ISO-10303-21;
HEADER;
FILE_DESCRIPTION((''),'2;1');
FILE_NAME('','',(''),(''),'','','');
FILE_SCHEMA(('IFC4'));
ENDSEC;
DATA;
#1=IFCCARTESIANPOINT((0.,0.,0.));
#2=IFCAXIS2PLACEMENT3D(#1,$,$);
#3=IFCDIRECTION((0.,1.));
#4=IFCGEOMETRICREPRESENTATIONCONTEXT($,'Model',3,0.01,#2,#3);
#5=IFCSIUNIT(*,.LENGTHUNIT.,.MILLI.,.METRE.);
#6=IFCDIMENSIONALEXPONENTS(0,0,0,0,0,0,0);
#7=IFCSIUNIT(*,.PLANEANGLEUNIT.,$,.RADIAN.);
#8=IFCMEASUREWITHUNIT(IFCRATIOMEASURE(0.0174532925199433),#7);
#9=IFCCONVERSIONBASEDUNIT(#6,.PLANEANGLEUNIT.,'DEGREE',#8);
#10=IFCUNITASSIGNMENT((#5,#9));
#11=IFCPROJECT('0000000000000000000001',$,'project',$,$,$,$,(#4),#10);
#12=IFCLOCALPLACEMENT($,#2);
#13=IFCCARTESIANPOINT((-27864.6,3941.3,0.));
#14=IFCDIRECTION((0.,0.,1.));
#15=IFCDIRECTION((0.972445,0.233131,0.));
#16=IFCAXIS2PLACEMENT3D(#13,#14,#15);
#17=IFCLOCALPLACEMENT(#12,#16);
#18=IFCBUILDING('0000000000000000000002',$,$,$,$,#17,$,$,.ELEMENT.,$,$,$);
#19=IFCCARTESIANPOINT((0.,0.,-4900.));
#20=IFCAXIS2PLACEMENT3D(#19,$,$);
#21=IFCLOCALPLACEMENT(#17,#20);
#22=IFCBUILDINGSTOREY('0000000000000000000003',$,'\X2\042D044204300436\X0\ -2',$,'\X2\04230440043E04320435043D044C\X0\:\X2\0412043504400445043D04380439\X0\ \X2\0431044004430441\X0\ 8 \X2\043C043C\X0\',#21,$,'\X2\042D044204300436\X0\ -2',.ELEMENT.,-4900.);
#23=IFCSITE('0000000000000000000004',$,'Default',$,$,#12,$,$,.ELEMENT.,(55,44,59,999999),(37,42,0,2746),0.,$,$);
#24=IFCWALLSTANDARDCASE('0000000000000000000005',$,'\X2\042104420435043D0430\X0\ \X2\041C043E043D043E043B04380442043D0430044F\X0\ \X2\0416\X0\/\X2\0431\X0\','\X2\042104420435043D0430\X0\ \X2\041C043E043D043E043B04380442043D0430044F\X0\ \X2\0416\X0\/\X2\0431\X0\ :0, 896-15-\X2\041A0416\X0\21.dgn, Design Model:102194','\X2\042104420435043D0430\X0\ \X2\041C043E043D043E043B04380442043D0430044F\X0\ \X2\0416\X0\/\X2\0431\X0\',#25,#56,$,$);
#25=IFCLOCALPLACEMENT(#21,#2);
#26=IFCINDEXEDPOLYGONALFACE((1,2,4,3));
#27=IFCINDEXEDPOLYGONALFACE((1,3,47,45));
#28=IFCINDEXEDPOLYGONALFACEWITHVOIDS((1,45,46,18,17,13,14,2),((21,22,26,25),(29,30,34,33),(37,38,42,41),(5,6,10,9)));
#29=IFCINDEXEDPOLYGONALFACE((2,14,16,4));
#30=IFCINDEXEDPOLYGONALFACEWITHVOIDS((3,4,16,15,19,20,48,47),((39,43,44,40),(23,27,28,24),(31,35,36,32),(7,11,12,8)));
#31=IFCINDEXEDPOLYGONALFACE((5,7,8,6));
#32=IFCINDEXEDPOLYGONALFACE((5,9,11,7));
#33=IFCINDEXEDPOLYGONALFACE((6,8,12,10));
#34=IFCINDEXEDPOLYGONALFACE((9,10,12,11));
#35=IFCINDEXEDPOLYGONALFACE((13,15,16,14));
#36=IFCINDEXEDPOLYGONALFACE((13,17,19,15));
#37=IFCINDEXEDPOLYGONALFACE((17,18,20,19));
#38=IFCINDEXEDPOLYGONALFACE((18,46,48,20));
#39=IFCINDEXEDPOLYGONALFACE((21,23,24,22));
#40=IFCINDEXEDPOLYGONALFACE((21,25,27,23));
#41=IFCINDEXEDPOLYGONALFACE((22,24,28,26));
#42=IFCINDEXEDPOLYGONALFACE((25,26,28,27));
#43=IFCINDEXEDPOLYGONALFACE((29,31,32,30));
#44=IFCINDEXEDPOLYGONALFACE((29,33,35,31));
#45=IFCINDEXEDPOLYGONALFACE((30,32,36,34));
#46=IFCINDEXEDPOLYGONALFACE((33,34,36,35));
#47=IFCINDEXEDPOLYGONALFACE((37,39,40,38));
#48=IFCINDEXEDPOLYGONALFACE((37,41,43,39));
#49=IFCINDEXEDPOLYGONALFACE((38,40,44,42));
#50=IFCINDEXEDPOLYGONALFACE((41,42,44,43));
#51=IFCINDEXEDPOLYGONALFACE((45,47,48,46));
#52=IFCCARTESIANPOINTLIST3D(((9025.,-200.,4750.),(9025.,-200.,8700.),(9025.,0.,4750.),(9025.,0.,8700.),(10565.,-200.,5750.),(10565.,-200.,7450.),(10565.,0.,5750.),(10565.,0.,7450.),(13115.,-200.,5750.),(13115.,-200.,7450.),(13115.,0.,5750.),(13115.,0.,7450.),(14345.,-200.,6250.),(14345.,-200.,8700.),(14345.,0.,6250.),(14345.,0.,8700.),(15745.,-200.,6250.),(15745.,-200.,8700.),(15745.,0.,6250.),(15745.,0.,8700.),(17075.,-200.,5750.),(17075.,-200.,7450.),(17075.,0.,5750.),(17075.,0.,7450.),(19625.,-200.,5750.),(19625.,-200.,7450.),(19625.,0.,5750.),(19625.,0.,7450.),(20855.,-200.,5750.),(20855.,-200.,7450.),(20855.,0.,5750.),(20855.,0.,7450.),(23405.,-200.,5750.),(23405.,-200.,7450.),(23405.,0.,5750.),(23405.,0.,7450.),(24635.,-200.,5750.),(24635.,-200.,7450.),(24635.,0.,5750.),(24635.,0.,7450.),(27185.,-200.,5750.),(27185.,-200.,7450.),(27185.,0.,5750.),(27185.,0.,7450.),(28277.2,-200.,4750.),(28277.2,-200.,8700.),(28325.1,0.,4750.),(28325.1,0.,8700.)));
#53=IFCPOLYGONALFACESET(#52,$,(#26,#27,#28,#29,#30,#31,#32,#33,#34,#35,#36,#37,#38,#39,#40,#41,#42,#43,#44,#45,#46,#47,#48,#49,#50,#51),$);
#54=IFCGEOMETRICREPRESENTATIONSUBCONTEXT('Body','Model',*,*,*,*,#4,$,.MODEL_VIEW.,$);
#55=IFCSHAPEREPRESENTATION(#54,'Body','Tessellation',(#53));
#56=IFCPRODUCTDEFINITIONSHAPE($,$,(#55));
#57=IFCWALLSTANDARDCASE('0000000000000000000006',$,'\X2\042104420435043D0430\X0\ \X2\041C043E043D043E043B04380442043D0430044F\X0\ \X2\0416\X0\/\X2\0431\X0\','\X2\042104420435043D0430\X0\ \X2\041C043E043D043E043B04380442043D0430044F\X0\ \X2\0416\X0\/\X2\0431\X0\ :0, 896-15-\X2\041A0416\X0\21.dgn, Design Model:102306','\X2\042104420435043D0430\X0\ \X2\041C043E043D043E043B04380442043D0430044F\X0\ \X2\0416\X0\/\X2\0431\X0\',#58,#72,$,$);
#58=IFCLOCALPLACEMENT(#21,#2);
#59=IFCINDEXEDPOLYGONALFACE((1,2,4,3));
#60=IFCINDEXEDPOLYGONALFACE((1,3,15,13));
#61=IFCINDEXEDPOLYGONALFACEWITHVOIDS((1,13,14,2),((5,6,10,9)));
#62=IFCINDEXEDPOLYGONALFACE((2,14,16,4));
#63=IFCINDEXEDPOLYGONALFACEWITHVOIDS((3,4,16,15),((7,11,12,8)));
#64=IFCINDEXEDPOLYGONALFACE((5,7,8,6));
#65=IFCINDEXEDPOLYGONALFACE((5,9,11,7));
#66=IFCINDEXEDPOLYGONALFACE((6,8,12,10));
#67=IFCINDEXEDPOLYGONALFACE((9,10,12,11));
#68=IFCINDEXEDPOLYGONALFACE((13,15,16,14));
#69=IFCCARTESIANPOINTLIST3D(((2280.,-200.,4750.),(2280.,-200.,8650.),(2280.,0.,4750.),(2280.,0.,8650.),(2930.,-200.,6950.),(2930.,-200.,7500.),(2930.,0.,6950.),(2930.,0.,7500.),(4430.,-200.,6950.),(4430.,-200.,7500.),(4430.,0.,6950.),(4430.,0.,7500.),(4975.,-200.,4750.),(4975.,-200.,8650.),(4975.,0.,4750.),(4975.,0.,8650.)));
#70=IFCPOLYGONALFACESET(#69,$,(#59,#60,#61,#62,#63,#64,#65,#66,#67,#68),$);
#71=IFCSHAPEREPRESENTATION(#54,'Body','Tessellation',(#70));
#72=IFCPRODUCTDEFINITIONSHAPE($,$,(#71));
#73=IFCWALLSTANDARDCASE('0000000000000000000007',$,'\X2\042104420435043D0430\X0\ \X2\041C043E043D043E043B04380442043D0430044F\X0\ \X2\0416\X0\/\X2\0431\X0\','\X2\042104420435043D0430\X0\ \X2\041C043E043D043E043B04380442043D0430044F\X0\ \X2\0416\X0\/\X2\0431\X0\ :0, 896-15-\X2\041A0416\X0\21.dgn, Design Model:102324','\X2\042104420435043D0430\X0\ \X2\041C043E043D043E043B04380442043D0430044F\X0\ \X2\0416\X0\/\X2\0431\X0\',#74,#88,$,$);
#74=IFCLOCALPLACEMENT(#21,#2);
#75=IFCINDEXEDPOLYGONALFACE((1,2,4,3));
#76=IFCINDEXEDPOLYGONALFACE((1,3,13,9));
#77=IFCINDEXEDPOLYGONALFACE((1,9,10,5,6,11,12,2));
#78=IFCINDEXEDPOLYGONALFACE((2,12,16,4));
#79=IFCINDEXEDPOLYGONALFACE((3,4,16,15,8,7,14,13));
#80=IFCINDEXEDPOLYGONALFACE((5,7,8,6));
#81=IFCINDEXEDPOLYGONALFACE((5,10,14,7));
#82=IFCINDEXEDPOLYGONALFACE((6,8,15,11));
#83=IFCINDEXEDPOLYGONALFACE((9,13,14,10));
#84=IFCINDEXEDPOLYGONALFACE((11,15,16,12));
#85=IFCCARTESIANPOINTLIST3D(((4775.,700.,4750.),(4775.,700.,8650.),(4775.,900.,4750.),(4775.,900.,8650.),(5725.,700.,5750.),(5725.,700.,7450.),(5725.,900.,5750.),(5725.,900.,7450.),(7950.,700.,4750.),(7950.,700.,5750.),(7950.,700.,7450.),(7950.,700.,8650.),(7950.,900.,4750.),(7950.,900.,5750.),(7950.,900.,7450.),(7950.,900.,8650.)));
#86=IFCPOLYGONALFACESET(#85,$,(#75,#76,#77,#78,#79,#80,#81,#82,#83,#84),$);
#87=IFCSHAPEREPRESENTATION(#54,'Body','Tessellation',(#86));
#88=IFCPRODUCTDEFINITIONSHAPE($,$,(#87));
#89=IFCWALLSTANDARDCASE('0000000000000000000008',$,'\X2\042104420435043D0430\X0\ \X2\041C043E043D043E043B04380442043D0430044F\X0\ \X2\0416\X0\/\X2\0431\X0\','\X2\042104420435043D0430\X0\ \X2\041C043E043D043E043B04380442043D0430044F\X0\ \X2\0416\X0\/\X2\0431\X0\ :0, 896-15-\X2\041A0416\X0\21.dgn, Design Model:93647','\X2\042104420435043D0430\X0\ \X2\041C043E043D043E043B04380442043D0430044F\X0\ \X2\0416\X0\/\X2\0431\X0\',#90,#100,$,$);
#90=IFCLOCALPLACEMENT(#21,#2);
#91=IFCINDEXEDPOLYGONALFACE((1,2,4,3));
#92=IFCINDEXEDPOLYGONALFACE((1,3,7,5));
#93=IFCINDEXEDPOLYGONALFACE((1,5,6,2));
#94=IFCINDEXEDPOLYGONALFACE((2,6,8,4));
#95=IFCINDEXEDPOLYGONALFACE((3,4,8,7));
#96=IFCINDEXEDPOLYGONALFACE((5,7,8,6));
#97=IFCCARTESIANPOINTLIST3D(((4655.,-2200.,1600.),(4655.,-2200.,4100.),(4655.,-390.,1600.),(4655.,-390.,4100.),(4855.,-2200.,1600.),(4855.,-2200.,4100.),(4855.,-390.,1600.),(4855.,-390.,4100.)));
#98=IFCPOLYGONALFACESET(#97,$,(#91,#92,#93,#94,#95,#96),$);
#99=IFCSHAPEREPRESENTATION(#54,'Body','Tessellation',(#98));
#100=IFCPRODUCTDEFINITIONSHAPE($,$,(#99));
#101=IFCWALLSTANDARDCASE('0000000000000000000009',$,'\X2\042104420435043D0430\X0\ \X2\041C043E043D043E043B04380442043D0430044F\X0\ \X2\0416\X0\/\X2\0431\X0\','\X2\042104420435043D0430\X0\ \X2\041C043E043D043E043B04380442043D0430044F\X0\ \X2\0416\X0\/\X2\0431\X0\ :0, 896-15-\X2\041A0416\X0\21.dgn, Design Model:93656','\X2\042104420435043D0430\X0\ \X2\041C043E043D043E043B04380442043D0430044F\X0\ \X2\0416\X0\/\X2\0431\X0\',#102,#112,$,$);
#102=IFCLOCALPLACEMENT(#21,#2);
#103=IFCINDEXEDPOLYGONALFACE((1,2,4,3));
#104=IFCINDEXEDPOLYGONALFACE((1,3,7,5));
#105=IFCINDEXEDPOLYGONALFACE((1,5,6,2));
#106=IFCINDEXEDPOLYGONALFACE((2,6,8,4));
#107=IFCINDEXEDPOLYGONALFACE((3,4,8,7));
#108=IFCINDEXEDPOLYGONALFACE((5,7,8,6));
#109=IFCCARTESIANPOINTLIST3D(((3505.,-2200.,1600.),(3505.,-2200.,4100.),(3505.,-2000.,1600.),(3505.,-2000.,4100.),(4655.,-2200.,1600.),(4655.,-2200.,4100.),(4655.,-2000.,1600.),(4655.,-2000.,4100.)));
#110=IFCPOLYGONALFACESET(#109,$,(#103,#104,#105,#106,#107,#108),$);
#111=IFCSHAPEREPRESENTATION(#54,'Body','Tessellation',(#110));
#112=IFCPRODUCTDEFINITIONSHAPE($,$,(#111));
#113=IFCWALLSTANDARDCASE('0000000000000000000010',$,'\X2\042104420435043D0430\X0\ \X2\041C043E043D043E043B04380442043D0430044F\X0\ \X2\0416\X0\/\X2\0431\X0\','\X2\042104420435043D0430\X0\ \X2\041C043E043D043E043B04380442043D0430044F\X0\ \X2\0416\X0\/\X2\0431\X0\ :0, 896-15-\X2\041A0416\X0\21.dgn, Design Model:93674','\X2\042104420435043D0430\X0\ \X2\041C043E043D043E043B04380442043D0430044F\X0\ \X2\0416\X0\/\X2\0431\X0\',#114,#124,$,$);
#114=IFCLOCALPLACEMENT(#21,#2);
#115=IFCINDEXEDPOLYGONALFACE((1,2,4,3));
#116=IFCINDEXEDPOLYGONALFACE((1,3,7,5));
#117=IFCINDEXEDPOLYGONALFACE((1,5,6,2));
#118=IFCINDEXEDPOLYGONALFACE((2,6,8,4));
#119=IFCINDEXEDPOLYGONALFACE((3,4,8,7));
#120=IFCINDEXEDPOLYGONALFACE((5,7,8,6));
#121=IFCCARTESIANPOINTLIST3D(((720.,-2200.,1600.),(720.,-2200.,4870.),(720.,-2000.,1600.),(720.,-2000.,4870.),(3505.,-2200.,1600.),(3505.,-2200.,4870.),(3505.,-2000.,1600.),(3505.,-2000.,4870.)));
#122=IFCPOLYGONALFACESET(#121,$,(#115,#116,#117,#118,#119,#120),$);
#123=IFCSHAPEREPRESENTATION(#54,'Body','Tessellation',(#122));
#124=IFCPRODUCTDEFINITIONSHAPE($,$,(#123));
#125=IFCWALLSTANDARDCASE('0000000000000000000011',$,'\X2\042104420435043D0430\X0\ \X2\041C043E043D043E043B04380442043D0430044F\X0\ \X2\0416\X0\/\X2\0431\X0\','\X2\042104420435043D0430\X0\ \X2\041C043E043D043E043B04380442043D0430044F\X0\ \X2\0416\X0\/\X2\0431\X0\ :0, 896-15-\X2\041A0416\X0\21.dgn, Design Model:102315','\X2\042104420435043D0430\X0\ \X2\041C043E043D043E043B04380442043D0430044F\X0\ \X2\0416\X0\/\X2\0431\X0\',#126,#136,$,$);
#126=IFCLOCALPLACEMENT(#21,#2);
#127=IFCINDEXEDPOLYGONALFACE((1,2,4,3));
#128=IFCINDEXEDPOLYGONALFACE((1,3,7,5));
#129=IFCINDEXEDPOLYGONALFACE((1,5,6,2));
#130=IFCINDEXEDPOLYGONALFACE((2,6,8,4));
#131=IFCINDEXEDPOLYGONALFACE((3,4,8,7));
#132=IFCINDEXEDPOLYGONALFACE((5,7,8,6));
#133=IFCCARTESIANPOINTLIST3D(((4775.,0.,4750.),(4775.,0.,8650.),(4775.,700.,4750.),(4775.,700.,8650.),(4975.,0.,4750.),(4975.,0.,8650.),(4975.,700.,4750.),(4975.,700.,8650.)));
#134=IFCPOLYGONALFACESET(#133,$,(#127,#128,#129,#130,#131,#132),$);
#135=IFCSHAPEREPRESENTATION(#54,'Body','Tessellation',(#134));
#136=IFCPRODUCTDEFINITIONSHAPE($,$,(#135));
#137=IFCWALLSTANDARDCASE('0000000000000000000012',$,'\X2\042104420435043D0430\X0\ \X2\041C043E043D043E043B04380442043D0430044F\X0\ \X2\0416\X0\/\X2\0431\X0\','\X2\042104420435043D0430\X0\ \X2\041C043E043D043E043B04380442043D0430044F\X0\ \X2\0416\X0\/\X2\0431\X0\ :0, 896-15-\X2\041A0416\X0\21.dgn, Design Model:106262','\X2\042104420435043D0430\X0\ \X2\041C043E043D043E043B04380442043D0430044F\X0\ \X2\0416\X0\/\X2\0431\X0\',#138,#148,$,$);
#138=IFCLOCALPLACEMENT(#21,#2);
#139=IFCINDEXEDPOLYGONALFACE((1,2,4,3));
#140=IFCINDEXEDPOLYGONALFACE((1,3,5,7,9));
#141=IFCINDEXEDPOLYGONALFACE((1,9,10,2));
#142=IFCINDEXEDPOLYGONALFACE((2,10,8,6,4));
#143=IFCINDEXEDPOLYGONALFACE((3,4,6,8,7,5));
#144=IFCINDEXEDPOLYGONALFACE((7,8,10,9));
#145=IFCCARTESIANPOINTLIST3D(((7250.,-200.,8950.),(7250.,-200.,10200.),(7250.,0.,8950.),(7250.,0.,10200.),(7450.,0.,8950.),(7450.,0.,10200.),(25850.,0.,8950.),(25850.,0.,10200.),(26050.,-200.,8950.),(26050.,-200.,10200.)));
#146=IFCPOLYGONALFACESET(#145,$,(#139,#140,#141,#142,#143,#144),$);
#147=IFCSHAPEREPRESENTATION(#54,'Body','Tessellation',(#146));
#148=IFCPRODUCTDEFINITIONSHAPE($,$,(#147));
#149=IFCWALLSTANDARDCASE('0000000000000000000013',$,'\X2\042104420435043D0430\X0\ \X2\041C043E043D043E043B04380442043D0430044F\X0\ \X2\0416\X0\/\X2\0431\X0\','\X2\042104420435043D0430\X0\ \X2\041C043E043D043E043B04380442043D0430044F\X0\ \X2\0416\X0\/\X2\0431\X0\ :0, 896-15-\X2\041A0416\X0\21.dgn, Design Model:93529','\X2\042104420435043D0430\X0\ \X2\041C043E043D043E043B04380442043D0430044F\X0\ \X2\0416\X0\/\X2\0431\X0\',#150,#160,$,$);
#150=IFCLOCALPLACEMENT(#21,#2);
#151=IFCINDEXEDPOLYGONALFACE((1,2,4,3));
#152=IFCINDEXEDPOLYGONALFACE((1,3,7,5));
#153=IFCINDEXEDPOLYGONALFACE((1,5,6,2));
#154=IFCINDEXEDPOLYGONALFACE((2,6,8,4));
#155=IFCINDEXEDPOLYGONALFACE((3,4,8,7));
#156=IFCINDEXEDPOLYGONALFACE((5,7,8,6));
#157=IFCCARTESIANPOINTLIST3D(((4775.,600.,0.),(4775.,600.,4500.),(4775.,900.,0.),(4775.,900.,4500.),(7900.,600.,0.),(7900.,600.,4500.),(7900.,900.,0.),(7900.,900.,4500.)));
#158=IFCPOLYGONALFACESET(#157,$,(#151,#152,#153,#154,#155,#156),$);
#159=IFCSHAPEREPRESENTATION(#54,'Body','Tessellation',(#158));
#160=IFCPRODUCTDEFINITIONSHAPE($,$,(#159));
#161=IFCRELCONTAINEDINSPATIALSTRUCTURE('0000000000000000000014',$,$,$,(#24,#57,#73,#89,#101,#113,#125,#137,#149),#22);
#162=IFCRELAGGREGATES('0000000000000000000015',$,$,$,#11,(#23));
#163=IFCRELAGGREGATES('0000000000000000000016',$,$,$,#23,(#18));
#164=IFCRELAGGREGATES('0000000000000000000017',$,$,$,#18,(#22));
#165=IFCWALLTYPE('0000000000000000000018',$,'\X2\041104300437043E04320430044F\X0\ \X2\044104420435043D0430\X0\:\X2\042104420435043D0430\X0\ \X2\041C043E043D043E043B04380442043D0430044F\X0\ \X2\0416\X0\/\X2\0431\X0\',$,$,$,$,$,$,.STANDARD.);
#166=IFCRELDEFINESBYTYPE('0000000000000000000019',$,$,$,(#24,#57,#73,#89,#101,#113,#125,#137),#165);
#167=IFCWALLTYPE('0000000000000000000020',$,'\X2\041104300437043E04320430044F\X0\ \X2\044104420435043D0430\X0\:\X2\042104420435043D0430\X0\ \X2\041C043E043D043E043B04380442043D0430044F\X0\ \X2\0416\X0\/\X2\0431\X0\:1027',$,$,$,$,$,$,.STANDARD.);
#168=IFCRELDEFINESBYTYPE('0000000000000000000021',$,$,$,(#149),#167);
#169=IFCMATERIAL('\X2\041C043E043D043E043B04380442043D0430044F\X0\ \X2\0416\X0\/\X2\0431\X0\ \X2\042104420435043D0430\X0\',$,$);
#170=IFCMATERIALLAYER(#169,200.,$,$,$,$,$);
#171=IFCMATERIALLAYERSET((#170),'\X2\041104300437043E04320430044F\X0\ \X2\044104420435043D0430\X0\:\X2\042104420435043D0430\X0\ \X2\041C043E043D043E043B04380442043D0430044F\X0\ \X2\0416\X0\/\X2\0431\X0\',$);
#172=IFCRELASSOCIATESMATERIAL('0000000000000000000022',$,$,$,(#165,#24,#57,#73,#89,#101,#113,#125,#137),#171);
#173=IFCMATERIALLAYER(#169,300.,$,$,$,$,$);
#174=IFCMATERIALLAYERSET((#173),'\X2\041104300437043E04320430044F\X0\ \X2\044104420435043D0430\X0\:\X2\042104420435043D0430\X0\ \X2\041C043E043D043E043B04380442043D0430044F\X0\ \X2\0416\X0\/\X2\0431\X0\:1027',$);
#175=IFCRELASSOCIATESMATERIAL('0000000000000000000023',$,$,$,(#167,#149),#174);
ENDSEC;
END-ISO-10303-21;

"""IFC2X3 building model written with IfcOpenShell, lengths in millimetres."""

from ifc_helpers import new_model, entity, si_unit, converted_unit, direction, frame, frame_2d, origin, origin_2d_with_axis, place, context, subcontext, project, spatial, polyline, rectangle, outline, extrude, material, layer, layer_set, layer_usage, type_object, element, save


model = new_model("IFC2X3")

# Units and contexts
model_context = context("Model", 3, precision=0.01, world=origin(), true_north=direction((0.0, 1.0)))
body_context = subcontext(model_context, "Body", "Model", "MODEL_VIEW")
ifc_project = project(units=[si_unit("LENGTHUNIT", "METRE", prefix="MILLI"), converted_unit("PLANEANGLEUNIT", "DEGREE", entity("IfcRatioMeasure", 0.0174532925199433), si_unit("PLANEANGLEUNIT", "RADIAN"), dimensions=[0, 0, 0, 0, 0, 0, 0])], contexts=[model_context])

# Site, building, storey
site_placement = place(None, origin())
site = spatial("IfcSite", under=ifc_project, at=site_placement, Name="Default", CompositionType="ELEMENT", RefLatitude=(55, 44, 59, 999999), RefLongitude=(37, 42, 0, 2746), RefElevation=0.0)
building_placement = place(site_placement, frame((-27864.6, 3941.3, 0.0), z_axis=(0.0, 0.0, 1.0), x_axis=(0.972445, 0.233131, 0.0)))
building = spatial("IfcBuilding", under=site, at=building_placement, CompositionType="ELEMENT")
storey_placement = place(building_placement, frame((0.0, 0.0, -4900.0)))
storey = spatial("IfcBuildingStorey", under=building, at=storey_placement, Name="Этаж -2", ObjectType="Уровень:Верхний брус 8 мм", LongName="Этаж -2", CompositionType="ELEMENT", Elevation=-4900.0)

# Wall, openings
ifc_material = material(Name="Монолитная Ж/б Стена")
ifc_layer_1 = layer(ifc_material, 200.0)
ifc_layer_set_1 = layer_set([ifc_layer_1], Name="Базовая стена:Стена Монолитная Ж/б")
ifc_layer_usage_1 = layer_usage(ifc_layer_set_1, "AXIS2", "NEGATIVE", 100.0)
wall_type_1 = type_object("IfcWallType", Name="Базовая стена:Стена Монолитная Ж/б", PredefinedType="STANDARD", material=ifc_layer_set_1)
wall_1_placement = place(storey_placement, frame((9025.0, -100.0, 4750.0)))
wall_1 = element("IfcWallStandardCase", 1, at=wall_1_placement, inside=storey, type_object=wall_type_1, material=ifc_layer_usage_1, Name="Стена Монолитная Ж/б", Description="Стена Монолитная Ж/б :0, 896-15-КЖ21.dgn, Design Model:102194", ObjectType="Стена Монолитная Ж/б", context=body_context, shape_type="SweptSolid", body=[
    extrude(outline(polyline([(19252.2, -100.0), (19300.1, 100.0), (7130.0, 100.0), (6880.0, 100.0), (200.0, 100.0), (0.0, 100.0), (0.0, -100.0), (19252.2, -100.0)])), origin(), (0.0, 0.0, 1.0), 3950.0),
])
opening_1_placement = place(wall_1_placement, origin())
element("IfcOpeningElement", 2, at=opening_1_placement, cuts=wall_1, ObjectType="Opening", context=body_context, shape_type="SweptSolid", body=[
    extrude(rectangle(XDim=1700.0, YDim=2550.0, at=origin_2d_with_axis()), frame((2815.0, -100.0, 1850.0), z_axis=(0.0, 1.0, 0.0), x_axis=(0.0, 0.0, -1.0)), (0.0, 0.0, 1.0), 200.0),
])
opening_2_placement = place(wall_1_placement, origin())
element("IfcOpeningElement", 3, at=opening_2_placement, cuts=wall_1, ObjectType="Opening", context=body_context, shape_type="SweptSolid", body=[
    extrude(rectangle(XDim=1700.0, YDim=2550.0, at=origin_2d_with_axis()), frame((9325.0, -100.0, 1850.0), z_axis=(0.0, 1.0, 0.0), x_axis=(0.0, 0.0, -1.0)), (0.0, 0.0, 1.0), 200.0),
])
opening_3_placement = place(wall_1_placement, origin())
element("IfcOpeningElement", 4, at=opening_3_placement, cuts=wall_1, ObjectType="Opening", context=body_context, shape_type="SweptSolid", body=[
    extrude(rectangle(XDim=1700.0, YDim=2550.0, at=origin_2d_with_axis()), frame((13105.0, -100.0, 1850.0), z_axis=(0.0, 1.0, 0.0), x_axis=(0.0, 0.0, -1.0)), (0.0, 0.0, 1.0), 200.0),
])
opening_4_placement = place(wall_1_placement, origin())
element("IfcOpeningElement", 5, at=opening_4_placement, cuts=wall_1, ObjectType="Opening", context=body_context, shape_type="SweptSolid", body=[
    extrude(rectangle(XDim=1700.0, YDim=2550.0, at=origin_2d_with_axis()), frame((16885.0, -100.0, 1850.0), z_axis=(0.0, 1.0, 0.0), x_axis=(0.0, 0.0, -1.0)), (0.0, 0.0, 1.0), 200.0),
])
opening_5_placement = place(wall_1_placement, origin())
element("IfcOpeningElement", 6, at=opening_5_placement, cuts=wall_1, ObjectType="Opening", context=body_context, shape_type="SweptSolid", body=[
    extrude(rectangle(XDim=2450.0, YDim=1400.0, at=origin_2d_with_axis()), frame((6020.0, -100.0, 2725.0), z_axis=(0.0, 1.0, 0.0), x_axis=(0.0, 0.0, -1.0)), (0.0, 0.0, 1.0), 200.0),
])

# Walls, openings
ifc_layer_usage_2 = layer_usage(ifc_layer_set_1, "AXIS2", "NEGATIVE", 100.0)
wall_2_placement = place(storey_placement, frame((4975.0, -100.0, 4750.0), z_axis=(0.0, 0.0, 1.0), x_axis=(-1.0, 0.0, 0.0)))
wall_2 = element("IfcWallStandardCase", 7, at=wall_2_placement, inside=storey, type_object=wall_type_1, material=ifc_layer_usage_2, Name="Стена Монолитная Ж/б", Description="Стена Монолитная Ж/б :0, 896-15-КЖ21.dgn, Design Model:102306", ObjectType="Стена Монолитная Ж/б", context=body_context, shape_type="SweptSolid", body=[
    extrude(rectangle(XDim=2695.0, YDim=200.0, at=frame_2d((1347.5, 0.0), x_axis=(-1.0, 0.0))), origin(), (0.0, 0.0, 1.0), 3900.0),
])
opening_6_placement = place(wall_2_placement, origin())
element("IfcOpeningElement", 8, at=opening_6_placement, cuts=wall_2, ObjectType="Opening", context=body_context, shape_type="SweptSolid", body=[
    extrude(rectangle(XDim=550.0, YDim=1500.0, at=origin_2d_with_axis()), frame((1295.0, -100.0, 2475.0), z_axis=(0.0, 1.0, 0.0), x_axis=(0.0, 0.0, -1.0)), (0.0, 0.0, 1.0), 200.0),
])
ifc_layer_usage_3 = layer_usage(ifc_layer_set_1, "AXIS2", "NEGATIVE", 100.0)
wall_3_placement = place(storey_placement, frame((4775.0, 800.0, 4750.0)))
wall_3 = element("IfcWallStandardCase", 9, at=wall_3_placement, inside=storey, type_object=wall_type_1, material=ifc_layer_usage_3, Name="Стена Монолитная Ж/б", Description="Стена Монолитная Ж/б :0, 896-15-КЖ21.dgn, Design Model:102324", ObjectType="Стена Монолитная Ж/б", context=body_context, shape_type="SweptSolid", body=[
    extrude(rectangle(XDim=3175.0, YDim=200.0, at=frame_2d((1587.5, 0.0), x_axis=(-1.0, 0.0))), origin(), (0.0, 0.0, 1.0), 3900.0),
])
opening_7_placement = place(wall_3_placement, origin())
element("IfcOpeningElement", 10, at=opening_7_placement, cuts=wall_3, ObjectType="Opening", context=body_context, shape_type="SweptSolid", body=[
    extrude(rectangle(XDim=1700.0, YDim=2550.0, at=origin_2d_with_axis()), frame((2225.0, -100.0, 1850.0), z_axis=(0.0, 1.0, 0.0), x_axis=(0.0, 0.0, -1.0)), (0.0, 0.0, 1.0), 200.0),
])

# Walls
ifc_layer_usage_4 = layer_usage(ifc_layer_set_1, "AXIS2", "NEGATIVE", 100.0)
wall_4_placement = place(storey_placement, frame((4755.0, -2200.0, 1600.0), z_axis=(0.0, 0.0, 1.0), x_axis=(0.0, 1.0, 0.0)))
element("IfcWallStandardCase", 11, at=wall_4_placement, inside=storey, type_object=wall_type_1, material=ifc_layer_usage_4, Name="Стена Монолитная Ж/б", Description="Стена Монолитная Ж/б :0, 896-15-КЖ21.dgn, Design Model:93647", ObjectType="Стена Монолитная Ж/б", context=body_context, shape_type="SweptSolid", body=[
    extrude(rectangle(XDim=1810.0, YDim=200.0, at=frame_2d((905.0, 0.0), x_axis=(-1.0, 0.0))), origin(), (0.0, 0.0, 1.0), 2500.0),
])
ifc_layer_usage_5 = layer_usage(ifc_layer_set_1, "AXIS2", "NEGATIVE", 100.0)
wall_5_placement = place(storey_placement, frame((3505.0, -2100.0, 1600.0)))
element("IfcWallStandardCase", 12, at=wall_5_placement, inside=storey, type_object=wall_type_1, material=ifc_layer_usage_5, Name="Стена Монолитная Ж/б", Description="Стена Монолитная Ж/б :0, 896-15-КЖ21.dgn, Design Model:93656", ObjectType="Стена Монолитная Ж/б", context=body_context, shape_type="SweptSolid", body=[
    extrude(rectangle(XDim=1150.0, YDim=200.0, at=frame_2d((575.0, 0.0), x_axis=(-1.0, 0.0))), origin(), (0.0, 0.0, 1.0), 2500.0),
])
ifc_layer_usage_6 = layer_usage(ifc_layer_set_1, "AXIS2", "NEGATIVE", 100.0)
wall_6_placement = place(storey_placement, frame((3505.0, -2100.0, 1600.0), z_axis=(0.0, 0.0, 1.0), x_axis=(-1.0, 0.0, 0.0)))
element("IfcWallStandardCase", 13, at=wall_6_placement, inside=storey, type_object=wall_type_1, material=ifc_layer_usage_6, Name="Стена Монолитная Ж/б", Description="Стена Монолитная Ж/б :0, 896-15-КЖ21.dgn, Design Model:93674", ObjectType="Стена Монолитная Ж/б", context=body_context, shape_type="SweptSolid", body=[
    extrude(rectangle(XDim=2785.0, YDim=200.0, at=frame_2d((1392.5, 0.0), x_axis=(-1.0, 0.0))), origin(), (0.0, 0.0, 1.0), 3270.0),
])
ifc_layer_usage_7 = layer_usage(ifc_layer_set_1, "AXIS2", "NEGATIVE", 100.0)
wall_7_placement = place(storey_placement, frame((4875.0, 700.0, 4750.0), z_axis=(0.0, 0.0, 1.0), x_axis=(0.0, -1.0, 0.0)))
element("IfcWallStandardCase", 14, at=wall_7_placement, inside=storey, type_object=wall_type_1, material=ifc_layer_usage_7, Name="Стена Монолитная Ж/б", Description="Стена Монолитная Ж/б :0, 896-15-КЖ21.dgn, Design Model:102315", ObjectType="Стена Монолитная Ж/б", context=body_context, shape_type="SweptSolid", body=[
    extrude(rectangle(XDim=700.0, YDim=200.0, at=frame_2d((350.0, 0.0), x_axis=(-1.0, 0.0))), origin(), (0.0, 0.0, 1.0), 3900.0),
])
ifc_layer_usage_8 = layer_usage(ifc_layer_set_1, "AXIS2", "NEGATIVE", 100.0)
wall_8_placement = place(storey_placement, frame((7250.0, -100.0, 8950.0)))
element("IfcWallStandardCase", 15, at=wall_8_placement, inside=storey, type_object=wall_type_1, material=ifc_layer_usage_8, Name="Стена Монолитная Ж/б", Description="Стена Монолитная Ж/б :0, 896-15-КЖ21.dgn, Design Model:106262", ObjectType="Стена Монолитная Ж/б", context=body_context, shape_type="SweptSolid", body=[
    extrude(outline(polyline([(18800.0, -100.0), (18600.0, 100.0), (200.0, 100.0), (0.0, 100.0), (0.0, -100.0), (18800.0, -100.0)])), origin(), (0.0, 0.0, 1.0), 1250.0),
])
ifc_layer_2 = layer(ifc_material, 300.0)
ifc_layer_set_2 = layer_set([ifc_layer_2], Name="Базовая стена:Стена Монолитная Ж/б:1027")
ifc_layer_usage_9 = layer_usage(ifc_layer_set_2, "AXIS2", "NEGATIVE", 150.0)
wall_type_2 = type_object("IfcWallType", Name="Базовая стена:Стена Монолитная Ж/б:1027", PredefinedType="STANDARD", material=ifc_layer_set_2)
wall_9_placement = place(storey_placement, frame((4775.0, 750.0, 0.0)))
element("IfcWallStandardCase", 16, at=wall_9_placement, inside=storey, type_object=wall_type_2, material=ifc_layer_usage_9, Name="Стена Монолитная Ж/б", Description="Стена Монолитная Ж/б :0, 896-15-КЖ21.dgn, Design Model:93529", ObjectType="Стена Монолитная Ж/б", context=body_context, shape_type="SweptSolid", body=[
    extrude(rectangle(XDim=3125.0, YDim=300.0, at=frame_2d((1562.5, 0.0), x_axis=(-1.0, 0.0))), origin(), (0.0, 0.0, 1.0), 4500.0),
])

save(model, "model.ifc")
